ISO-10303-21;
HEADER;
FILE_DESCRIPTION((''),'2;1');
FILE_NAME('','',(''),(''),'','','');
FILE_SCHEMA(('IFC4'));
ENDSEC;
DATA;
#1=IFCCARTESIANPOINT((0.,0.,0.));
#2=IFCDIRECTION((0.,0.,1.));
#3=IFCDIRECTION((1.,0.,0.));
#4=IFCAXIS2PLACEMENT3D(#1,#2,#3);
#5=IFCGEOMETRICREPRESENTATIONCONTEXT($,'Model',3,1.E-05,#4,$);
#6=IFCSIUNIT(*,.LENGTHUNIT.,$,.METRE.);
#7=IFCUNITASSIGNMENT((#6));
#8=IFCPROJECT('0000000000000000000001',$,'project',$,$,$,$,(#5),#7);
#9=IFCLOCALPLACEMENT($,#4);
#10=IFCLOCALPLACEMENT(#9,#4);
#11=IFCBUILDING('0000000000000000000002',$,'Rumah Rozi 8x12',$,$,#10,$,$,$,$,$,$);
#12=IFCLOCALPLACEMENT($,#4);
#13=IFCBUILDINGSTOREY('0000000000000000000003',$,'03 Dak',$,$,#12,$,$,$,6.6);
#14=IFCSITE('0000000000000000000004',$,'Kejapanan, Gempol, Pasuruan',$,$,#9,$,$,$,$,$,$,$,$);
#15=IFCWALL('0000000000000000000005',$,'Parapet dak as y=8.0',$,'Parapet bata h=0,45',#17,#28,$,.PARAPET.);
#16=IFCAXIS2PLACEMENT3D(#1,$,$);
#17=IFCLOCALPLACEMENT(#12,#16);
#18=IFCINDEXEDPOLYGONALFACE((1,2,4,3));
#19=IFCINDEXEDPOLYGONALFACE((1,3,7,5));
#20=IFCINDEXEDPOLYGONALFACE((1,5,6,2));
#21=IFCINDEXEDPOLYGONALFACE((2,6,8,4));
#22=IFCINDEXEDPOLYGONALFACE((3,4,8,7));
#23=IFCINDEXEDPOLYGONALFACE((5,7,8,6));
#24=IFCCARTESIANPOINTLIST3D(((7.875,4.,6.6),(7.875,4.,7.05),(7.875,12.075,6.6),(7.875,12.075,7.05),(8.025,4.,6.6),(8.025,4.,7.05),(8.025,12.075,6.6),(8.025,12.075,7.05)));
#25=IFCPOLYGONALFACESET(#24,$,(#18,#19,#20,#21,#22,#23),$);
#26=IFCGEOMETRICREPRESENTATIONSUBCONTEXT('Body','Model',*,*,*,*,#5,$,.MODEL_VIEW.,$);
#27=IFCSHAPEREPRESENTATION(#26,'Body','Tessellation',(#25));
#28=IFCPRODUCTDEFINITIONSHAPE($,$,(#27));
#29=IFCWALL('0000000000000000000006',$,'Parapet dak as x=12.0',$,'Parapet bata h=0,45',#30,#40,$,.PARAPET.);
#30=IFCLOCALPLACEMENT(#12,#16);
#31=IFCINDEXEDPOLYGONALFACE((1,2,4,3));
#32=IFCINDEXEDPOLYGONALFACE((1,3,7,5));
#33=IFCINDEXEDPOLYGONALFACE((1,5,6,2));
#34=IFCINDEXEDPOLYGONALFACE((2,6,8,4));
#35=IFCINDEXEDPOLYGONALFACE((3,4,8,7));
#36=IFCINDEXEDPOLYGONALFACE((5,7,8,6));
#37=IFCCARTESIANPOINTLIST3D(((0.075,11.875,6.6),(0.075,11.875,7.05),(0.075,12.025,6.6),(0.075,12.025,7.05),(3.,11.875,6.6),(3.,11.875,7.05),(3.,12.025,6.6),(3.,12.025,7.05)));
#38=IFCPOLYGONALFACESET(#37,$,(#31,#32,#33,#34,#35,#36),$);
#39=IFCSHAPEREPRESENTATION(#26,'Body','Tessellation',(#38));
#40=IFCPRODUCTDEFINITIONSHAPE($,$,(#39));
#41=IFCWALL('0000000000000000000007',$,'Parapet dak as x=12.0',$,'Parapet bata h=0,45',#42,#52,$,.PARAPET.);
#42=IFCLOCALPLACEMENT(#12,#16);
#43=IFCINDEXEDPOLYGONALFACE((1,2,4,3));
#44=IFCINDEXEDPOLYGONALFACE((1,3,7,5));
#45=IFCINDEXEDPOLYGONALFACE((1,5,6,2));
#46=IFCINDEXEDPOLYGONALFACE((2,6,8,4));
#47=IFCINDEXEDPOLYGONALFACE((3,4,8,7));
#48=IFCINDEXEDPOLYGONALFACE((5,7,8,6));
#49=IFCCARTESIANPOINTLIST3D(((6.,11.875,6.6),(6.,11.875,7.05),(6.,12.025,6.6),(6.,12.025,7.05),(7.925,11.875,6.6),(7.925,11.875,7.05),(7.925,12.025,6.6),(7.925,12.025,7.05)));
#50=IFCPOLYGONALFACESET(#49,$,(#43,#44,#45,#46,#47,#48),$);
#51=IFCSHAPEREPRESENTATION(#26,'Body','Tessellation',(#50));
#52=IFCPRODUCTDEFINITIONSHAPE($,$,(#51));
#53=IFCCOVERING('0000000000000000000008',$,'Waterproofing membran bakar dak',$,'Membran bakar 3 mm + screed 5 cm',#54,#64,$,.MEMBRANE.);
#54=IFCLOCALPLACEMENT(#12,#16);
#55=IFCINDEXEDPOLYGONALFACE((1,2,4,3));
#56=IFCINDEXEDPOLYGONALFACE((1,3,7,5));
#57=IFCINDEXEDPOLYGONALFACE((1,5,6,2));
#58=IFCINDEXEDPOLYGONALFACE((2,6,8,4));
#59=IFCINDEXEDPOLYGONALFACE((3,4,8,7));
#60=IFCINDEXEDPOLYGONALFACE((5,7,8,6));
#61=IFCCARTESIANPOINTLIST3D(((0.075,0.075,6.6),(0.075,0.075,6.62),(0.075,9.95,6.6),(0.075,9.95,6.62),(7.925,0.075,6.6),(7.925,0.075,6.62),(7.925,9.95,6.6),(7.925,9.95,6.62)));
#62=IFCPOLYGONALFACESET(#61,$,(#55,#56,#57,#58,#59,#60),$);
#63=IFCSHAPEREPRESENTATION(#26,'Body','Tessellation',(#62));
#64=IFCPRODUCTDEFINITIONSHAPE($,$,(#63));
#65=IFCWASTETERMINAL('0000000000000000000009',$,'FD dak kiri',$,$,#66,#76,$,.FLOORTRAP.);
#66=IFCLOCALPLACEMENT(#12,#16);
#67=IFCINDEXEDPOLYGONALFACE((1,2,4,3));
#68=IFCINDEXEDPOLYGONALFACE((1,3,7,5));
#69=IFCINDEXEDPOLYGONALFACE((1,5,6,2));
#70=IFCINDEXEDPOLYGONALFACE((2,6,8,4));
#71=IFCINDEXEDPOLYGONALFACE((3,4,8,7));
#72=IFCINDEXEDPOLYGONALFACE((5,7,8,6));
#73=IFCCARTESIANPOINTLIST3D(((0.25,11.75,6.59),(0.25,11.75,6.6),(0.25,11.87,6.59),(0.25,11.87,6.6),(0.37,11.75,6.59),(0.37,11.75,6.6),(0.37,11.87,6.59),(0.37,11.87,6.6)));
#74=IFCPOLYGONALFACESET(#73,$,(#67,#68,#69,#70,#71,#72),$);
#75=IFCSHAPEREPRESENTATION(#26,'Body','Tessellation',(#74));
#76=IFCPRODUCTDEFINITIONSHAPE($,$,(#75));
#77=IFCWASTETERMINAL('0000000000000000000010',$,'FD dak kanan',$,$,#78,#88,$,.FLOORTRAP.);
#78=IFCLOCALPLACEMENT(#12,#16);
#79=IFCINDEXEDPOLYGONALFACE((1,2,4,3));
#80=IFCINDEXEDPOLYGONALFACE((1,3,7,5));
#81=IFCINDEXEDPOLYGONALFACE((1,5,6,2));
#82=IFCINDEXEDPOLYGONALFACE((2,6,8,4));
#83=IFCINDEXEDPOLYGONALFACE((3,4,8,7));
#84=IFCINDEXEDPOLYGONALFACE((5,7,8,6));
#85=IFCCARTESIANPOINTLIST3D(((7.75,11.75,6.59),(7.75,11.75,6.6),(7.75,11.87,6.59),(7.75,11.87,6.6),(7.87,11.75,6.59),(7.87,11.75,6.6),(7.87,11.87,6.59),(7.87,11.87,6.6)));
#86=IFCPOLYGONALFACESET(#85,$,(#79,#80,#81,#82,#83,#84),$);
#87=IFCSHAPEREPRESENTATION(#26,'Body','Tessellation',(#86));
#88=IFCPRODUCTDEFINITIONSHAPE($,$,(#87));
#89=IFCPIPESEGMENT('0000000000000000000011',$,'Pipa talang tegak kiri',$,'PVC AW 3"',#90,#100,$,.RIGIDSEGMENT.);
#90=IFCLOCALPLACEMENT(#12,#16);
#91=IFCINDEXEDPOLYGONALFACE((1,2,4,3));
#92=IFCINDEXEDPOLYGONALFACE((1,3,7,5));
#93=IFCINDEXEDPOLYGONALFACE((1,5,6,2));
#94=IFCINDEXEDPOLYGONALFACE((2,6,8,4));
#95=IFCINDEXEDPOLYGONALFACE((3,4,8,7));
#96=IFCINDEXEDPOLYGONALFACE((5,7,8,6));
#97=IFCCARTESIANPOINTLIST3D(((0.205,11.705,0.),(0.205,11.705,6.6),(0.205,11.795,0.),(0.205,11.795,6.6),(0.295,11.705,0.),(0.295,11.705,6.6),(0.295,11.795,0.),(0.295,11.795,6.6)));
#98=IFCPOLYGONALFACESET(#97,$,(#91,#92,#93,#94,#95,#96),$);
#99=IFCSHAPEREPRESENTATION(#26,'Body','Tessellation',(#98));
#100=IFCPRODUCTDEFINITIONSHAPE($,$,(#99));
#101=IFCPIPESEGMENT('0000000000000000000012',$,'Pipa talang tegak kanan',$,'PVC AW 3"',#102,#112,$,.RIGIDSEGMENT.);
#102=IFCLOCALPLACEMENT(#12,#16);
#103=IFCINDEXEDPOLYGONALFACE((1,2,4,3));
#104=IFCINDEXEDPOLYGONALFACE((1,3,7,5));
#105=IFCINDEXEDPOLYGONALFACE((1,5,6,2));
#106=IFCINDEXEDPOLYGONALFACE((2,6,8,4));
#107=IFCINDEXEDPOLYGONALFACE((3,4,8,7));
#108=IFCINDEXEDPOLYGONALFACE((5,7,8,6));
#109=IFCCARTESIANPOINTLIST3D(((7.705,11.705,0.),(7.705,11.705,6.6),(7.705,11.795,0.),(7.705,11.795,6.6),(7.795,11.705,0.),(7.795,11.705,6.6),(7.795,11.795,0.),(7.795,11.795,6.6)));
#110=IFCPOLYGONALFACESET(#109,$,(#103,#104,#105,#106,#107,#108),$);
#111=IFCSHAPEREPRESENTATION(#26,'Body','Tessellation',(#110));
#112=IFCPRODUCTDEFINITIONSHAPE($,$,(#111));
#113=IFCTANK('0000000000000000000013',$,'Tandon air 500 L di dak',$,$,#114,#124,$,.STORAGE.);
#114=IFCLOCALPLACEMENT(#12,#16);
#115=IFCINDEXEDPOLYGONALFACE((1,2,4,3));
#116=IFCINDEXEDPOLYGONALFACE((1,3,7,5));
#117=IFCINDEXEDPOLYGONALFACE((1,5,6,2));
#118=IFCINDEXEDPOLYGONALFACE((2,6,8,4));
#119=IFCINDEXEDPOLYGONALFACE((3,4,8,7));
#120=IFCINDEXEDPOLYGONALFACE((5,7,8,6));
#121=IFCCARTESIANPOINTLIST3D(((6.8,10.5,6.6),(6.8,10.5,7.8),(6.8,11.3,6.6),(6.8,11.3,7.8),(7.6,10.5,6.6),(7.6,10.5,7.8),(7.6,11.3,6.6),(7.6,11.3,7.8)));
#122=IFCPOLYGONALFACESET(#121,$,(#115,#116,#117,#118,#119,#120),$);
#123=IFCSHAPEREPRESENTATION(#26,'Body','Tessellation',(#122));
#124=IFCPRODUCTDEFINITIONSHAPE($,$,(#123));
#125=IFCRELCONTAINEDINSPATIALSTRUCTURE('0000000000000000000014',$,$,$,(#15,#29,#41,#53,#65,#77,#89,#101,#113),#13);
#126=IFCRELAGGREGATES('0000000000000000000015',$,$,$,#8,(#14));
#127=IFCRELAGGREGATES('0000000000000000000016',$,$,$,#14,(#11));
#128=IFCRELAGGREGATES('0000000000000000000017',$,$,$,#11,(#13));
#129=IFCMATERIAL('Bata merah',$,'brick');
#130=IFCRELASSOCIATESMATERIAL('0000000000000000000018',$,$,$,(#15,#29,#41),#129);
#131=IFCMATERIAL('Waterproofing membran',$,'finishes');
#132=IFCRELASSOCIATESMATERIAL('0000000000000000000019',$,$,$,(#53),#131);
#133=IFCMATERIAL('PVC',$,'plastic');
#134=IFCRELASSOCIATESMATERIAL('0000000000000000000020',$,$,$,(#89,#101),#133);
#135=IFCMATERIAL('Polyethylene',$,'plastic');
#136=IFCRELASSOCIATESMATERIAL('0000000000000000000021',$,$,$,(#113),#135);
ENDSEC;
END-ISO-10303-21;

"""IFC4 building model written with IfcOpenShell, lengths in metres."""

from ifc_helpers import new_model, si_unit, frame, origin_with_axes, place, context, subcontext, project, spatial, line, indexed_curve, outline, extrude, material, element, save


model = new_model("IFC4")

# Units and contexts
model_context = context("Model", 3, precision=1e-05, world=origin_with_axes())
body_context = subcontext(model_context, "Body", "Model", "MODEL_VIEW")
ifc_project = project(units=[si_unit("LENGTHUNIT", "METRE")], contexts=[model_context])

# Site, building, storey
site_placement = place(None, origin_with_axes())
site = spatial("IfcSite", under=ifc_project, at=site_placement, Name="Kejapanan, Gempol, Pasuruan")
building_placement = place(site_placement, origin_with_axes())
building = spatial("IfcBuilding", under=site, at=building_placement, Name="Rumah Rozi 8x12")
storey_placement = place(None, origin_with_axes())
storey = spatial("IfcBuildingStorey", under=building, at=storey_placement, Name="03 Dak", Elevation=6.6)

# Walls
ifc_material_1 = material(Name="Bata merah", Category="brick")
wall_1_placement = place(storey_placement, origin_with_axes())
element("IfcWall", 1, at=wall_1_placement, inside=storey, material=ifc_material_1, Name="Parapet dak as y=8.0", ObjectType="Parapet bata h=0,45", PredefinedType="PARAPET", context=body_context, shape_type="SweptSolid", body=[
    extrude(outline(indexed_curve([(7.875, 4.0), (8.025, 4.0), (8.025, 12.075), (7.875, 12.075)], segments=[line(1, 2, 3, 4, 1)])), frame((0.0, 0.0, 6.6), z_axis=(0.0, 0.0, 1.0), x_axis=(1.0, 0.0, 0.0)), (0.0, 0.0, 1.0), 0.45),
])
wall_2_placement = place(storey_placement, origin_with_axes())
element("IfcWall", 2, at=wall_2_placement, inside=storey, material=ifc_material_1, Name="Parapet dak as x=12.0", ObjectType="Parapet bata h=0,45", PredefinedType="PARAPET", context=body_context, shape_type="SweptSolid", body=[
    extrude(outline(indexed_curve([(0.075, 11.875), (3.0, 11.875), (3.0, 12.025), (0.075, 12.025)], segments=[line(1, 2, 3, 4, 1)])), frame((0.0, 0.0, 6.6), z_axis=(0.0, 0.0, 1.0), x_axis=(1.0, 0.0, 0.0)), (0.0, 0.0, 1.0), 0.45),
])
wall_3_placement = place(storey_placement, origin_with_axes())
element("IfcWall", 3, at=wall_3_placement, inside=storey, material=ifc_material_1, Name="Parapet dak as x=12.0", ObjectType="Parapet bata h=0,45", PredefinedType="PARAPET", context=body_context, shape_type="SweptSolid", body=[
    extrude(outline(indexed_curve([(6.0, 11.875), (7.925, 11.875), (7.925, 12.025), (6.0, 12.025)], segments=[line(1, 2, 3, 4, 1)])), frame((0.0, 0.0, 6.6), z_axis=(0.0, 0.0, 1.0), x_axis=(1.0, 0.0, 0.0)), (0.0, 0.0, 1.0), 0.45),
])

# Covering
ifc_material_2 = material(Name="Waterproofing membran", Category="finishes")
covering_placement = place(storey_placement, origin_with_axes())
element("IfcCovering", 4, at=covering_placement, inside=storey, material=ifc_material_2, Name="Waterproofing membran bakar dak", ObjectType="Membran bakar 3 mm + screed 5 cm", PredefinedType="MEMBRANE", context=body_context, shape_type="SweptSolid", body=[
    extrude(outline(indexed_curve([(0.075, 0.075), (7.925, 0.075), (7.925, 9.95), (0.075, 9.95)], segments=[line(1, 2, 3, 4, 1)])), frame((0.0, 0.0, 6.6), z_axis=(0.0, 0.0, 1.0), x_axis=(1.0, 0.0, 0.0)), (0.0, 0.0, 1.0), 0.02),
])

# Waste terminals
waste_terminal_1_placement = place(storey_placement, origin_with_axes())
element("IfcWasteTerminal", 5, at=waste_terminal_1_placement, inside=storey, Name="FD dak kiri", PredefinedType="FLOORTRAP", context=body_context, shape_type="SweptSolid", body=[
    extrude(outline(indexed_curve([(0.25, 11.75), (0.37, 11.75), (0.37, 11.87), (0.25, 11.87)], segments=[line(1, 2, 3, 4, 1)])), frame((0.0, 0.0, 6.59), z_axis=(0.0, 0.0, 1.0), x_axis=(1.0, 0.0, 0.0)), (0.0, 0.0, 1.0), 0.01),
])
waste_terminal_2_placement = place(storey_placement, origin_with_axes())
element("IfcWasteTerminal", 6, at=waste_terminal_2_placement, inside=storey, Name="FD dak kanan", PredefinedType="FLOORTRAP", context=body_context, shape_type="SweptSolid", body=[
    extrude(outline(indexed_curve([(7.75, 11.75), (7.87, 11.75), (7.87, 11.87), (7.75, 11.87)], segments=[line(1, 2, 3, 4, 1)])), frame((0.0, 0.0, 6.59), z_axis=(0.0, 0.0, 1.0), x_axis=(1.0, 0.0, 0.0)), (0.0, 0.0, 1.0), 0.01),
])

# Pipe segments
ifc_material_3 = material(Name="PVC", Category="plastic")
pipe_segment_1_placement = place(storey_placement, origin_with_axes())
element("IfcPipeSegment", 7, at=pipe_segment_1_placement, inside=storey, material=ifc_material_3, Name="Pipa talang tegak kiri", ObjectType="PVC AW 3\"", PredefinedType="RIGIDSEGMENT", context=body_context, shape_type="SweptSolid", body=[
    extrude(outline(indexed_curve([(0.205, 11.705), (0.295, 11.705), (0.295, 11.795), (0.205, 11.795)], segments=[line(1, 2, 3, 4, 1)])), origin_with_axes(), (0.0, 0.0, 1.0), 6.6),
])
pipe_segment_2_placement = place(storey_placement, origin_with_axes())
element("IfcPipeSegment", 8, at=pipe_segment_2_placement, inside=storey, material=ifc_material_3, Name="Pipa talang tegak kanan", ObjectType="PVC AW 3\"", PredefinedType="RIGIDSEGMENT", context=body_context, shape_type="SweptSolid", body=[
    extrude(outline(indexed_curve([(7.705, 11.705), (7.795, 11.705), (7.795, 11.795), (7.705, 11.795)], segments=[line(1, 2, 3, 4, 1)])), origin_with_axes(), (0.0, 0.0, 1.0), 6.6),
])

# Tank
ifc_material_4 = material(Name="Polyethylene", Category="plastic")
tank_placement = place(storey_placement, origin_with_axes())
element("IfcTank", 9, at=tank_placement, inside=storey, material=ifc_material_4, Name="Tandon air 500 L di dak", PredefinedType="STORAGE", context=body_context, shape_type="SweptSolid", body=[
    extrude(outline(indexed_curve([(6.8, 10.5), (7.6, 10.5), (7.6, 11.3), (6.8, 11.3)], segments=[line(1, 2, 3, 4, 1)])), frame((0.0, 0.0, 6.6), z_axis=(0.0, 0.0, 1.0), x_axis=(1.0, 0.0, 0.0)), (0.0, 0.0, 1.0), 1.2),
])

save(model, "model.ifc")
